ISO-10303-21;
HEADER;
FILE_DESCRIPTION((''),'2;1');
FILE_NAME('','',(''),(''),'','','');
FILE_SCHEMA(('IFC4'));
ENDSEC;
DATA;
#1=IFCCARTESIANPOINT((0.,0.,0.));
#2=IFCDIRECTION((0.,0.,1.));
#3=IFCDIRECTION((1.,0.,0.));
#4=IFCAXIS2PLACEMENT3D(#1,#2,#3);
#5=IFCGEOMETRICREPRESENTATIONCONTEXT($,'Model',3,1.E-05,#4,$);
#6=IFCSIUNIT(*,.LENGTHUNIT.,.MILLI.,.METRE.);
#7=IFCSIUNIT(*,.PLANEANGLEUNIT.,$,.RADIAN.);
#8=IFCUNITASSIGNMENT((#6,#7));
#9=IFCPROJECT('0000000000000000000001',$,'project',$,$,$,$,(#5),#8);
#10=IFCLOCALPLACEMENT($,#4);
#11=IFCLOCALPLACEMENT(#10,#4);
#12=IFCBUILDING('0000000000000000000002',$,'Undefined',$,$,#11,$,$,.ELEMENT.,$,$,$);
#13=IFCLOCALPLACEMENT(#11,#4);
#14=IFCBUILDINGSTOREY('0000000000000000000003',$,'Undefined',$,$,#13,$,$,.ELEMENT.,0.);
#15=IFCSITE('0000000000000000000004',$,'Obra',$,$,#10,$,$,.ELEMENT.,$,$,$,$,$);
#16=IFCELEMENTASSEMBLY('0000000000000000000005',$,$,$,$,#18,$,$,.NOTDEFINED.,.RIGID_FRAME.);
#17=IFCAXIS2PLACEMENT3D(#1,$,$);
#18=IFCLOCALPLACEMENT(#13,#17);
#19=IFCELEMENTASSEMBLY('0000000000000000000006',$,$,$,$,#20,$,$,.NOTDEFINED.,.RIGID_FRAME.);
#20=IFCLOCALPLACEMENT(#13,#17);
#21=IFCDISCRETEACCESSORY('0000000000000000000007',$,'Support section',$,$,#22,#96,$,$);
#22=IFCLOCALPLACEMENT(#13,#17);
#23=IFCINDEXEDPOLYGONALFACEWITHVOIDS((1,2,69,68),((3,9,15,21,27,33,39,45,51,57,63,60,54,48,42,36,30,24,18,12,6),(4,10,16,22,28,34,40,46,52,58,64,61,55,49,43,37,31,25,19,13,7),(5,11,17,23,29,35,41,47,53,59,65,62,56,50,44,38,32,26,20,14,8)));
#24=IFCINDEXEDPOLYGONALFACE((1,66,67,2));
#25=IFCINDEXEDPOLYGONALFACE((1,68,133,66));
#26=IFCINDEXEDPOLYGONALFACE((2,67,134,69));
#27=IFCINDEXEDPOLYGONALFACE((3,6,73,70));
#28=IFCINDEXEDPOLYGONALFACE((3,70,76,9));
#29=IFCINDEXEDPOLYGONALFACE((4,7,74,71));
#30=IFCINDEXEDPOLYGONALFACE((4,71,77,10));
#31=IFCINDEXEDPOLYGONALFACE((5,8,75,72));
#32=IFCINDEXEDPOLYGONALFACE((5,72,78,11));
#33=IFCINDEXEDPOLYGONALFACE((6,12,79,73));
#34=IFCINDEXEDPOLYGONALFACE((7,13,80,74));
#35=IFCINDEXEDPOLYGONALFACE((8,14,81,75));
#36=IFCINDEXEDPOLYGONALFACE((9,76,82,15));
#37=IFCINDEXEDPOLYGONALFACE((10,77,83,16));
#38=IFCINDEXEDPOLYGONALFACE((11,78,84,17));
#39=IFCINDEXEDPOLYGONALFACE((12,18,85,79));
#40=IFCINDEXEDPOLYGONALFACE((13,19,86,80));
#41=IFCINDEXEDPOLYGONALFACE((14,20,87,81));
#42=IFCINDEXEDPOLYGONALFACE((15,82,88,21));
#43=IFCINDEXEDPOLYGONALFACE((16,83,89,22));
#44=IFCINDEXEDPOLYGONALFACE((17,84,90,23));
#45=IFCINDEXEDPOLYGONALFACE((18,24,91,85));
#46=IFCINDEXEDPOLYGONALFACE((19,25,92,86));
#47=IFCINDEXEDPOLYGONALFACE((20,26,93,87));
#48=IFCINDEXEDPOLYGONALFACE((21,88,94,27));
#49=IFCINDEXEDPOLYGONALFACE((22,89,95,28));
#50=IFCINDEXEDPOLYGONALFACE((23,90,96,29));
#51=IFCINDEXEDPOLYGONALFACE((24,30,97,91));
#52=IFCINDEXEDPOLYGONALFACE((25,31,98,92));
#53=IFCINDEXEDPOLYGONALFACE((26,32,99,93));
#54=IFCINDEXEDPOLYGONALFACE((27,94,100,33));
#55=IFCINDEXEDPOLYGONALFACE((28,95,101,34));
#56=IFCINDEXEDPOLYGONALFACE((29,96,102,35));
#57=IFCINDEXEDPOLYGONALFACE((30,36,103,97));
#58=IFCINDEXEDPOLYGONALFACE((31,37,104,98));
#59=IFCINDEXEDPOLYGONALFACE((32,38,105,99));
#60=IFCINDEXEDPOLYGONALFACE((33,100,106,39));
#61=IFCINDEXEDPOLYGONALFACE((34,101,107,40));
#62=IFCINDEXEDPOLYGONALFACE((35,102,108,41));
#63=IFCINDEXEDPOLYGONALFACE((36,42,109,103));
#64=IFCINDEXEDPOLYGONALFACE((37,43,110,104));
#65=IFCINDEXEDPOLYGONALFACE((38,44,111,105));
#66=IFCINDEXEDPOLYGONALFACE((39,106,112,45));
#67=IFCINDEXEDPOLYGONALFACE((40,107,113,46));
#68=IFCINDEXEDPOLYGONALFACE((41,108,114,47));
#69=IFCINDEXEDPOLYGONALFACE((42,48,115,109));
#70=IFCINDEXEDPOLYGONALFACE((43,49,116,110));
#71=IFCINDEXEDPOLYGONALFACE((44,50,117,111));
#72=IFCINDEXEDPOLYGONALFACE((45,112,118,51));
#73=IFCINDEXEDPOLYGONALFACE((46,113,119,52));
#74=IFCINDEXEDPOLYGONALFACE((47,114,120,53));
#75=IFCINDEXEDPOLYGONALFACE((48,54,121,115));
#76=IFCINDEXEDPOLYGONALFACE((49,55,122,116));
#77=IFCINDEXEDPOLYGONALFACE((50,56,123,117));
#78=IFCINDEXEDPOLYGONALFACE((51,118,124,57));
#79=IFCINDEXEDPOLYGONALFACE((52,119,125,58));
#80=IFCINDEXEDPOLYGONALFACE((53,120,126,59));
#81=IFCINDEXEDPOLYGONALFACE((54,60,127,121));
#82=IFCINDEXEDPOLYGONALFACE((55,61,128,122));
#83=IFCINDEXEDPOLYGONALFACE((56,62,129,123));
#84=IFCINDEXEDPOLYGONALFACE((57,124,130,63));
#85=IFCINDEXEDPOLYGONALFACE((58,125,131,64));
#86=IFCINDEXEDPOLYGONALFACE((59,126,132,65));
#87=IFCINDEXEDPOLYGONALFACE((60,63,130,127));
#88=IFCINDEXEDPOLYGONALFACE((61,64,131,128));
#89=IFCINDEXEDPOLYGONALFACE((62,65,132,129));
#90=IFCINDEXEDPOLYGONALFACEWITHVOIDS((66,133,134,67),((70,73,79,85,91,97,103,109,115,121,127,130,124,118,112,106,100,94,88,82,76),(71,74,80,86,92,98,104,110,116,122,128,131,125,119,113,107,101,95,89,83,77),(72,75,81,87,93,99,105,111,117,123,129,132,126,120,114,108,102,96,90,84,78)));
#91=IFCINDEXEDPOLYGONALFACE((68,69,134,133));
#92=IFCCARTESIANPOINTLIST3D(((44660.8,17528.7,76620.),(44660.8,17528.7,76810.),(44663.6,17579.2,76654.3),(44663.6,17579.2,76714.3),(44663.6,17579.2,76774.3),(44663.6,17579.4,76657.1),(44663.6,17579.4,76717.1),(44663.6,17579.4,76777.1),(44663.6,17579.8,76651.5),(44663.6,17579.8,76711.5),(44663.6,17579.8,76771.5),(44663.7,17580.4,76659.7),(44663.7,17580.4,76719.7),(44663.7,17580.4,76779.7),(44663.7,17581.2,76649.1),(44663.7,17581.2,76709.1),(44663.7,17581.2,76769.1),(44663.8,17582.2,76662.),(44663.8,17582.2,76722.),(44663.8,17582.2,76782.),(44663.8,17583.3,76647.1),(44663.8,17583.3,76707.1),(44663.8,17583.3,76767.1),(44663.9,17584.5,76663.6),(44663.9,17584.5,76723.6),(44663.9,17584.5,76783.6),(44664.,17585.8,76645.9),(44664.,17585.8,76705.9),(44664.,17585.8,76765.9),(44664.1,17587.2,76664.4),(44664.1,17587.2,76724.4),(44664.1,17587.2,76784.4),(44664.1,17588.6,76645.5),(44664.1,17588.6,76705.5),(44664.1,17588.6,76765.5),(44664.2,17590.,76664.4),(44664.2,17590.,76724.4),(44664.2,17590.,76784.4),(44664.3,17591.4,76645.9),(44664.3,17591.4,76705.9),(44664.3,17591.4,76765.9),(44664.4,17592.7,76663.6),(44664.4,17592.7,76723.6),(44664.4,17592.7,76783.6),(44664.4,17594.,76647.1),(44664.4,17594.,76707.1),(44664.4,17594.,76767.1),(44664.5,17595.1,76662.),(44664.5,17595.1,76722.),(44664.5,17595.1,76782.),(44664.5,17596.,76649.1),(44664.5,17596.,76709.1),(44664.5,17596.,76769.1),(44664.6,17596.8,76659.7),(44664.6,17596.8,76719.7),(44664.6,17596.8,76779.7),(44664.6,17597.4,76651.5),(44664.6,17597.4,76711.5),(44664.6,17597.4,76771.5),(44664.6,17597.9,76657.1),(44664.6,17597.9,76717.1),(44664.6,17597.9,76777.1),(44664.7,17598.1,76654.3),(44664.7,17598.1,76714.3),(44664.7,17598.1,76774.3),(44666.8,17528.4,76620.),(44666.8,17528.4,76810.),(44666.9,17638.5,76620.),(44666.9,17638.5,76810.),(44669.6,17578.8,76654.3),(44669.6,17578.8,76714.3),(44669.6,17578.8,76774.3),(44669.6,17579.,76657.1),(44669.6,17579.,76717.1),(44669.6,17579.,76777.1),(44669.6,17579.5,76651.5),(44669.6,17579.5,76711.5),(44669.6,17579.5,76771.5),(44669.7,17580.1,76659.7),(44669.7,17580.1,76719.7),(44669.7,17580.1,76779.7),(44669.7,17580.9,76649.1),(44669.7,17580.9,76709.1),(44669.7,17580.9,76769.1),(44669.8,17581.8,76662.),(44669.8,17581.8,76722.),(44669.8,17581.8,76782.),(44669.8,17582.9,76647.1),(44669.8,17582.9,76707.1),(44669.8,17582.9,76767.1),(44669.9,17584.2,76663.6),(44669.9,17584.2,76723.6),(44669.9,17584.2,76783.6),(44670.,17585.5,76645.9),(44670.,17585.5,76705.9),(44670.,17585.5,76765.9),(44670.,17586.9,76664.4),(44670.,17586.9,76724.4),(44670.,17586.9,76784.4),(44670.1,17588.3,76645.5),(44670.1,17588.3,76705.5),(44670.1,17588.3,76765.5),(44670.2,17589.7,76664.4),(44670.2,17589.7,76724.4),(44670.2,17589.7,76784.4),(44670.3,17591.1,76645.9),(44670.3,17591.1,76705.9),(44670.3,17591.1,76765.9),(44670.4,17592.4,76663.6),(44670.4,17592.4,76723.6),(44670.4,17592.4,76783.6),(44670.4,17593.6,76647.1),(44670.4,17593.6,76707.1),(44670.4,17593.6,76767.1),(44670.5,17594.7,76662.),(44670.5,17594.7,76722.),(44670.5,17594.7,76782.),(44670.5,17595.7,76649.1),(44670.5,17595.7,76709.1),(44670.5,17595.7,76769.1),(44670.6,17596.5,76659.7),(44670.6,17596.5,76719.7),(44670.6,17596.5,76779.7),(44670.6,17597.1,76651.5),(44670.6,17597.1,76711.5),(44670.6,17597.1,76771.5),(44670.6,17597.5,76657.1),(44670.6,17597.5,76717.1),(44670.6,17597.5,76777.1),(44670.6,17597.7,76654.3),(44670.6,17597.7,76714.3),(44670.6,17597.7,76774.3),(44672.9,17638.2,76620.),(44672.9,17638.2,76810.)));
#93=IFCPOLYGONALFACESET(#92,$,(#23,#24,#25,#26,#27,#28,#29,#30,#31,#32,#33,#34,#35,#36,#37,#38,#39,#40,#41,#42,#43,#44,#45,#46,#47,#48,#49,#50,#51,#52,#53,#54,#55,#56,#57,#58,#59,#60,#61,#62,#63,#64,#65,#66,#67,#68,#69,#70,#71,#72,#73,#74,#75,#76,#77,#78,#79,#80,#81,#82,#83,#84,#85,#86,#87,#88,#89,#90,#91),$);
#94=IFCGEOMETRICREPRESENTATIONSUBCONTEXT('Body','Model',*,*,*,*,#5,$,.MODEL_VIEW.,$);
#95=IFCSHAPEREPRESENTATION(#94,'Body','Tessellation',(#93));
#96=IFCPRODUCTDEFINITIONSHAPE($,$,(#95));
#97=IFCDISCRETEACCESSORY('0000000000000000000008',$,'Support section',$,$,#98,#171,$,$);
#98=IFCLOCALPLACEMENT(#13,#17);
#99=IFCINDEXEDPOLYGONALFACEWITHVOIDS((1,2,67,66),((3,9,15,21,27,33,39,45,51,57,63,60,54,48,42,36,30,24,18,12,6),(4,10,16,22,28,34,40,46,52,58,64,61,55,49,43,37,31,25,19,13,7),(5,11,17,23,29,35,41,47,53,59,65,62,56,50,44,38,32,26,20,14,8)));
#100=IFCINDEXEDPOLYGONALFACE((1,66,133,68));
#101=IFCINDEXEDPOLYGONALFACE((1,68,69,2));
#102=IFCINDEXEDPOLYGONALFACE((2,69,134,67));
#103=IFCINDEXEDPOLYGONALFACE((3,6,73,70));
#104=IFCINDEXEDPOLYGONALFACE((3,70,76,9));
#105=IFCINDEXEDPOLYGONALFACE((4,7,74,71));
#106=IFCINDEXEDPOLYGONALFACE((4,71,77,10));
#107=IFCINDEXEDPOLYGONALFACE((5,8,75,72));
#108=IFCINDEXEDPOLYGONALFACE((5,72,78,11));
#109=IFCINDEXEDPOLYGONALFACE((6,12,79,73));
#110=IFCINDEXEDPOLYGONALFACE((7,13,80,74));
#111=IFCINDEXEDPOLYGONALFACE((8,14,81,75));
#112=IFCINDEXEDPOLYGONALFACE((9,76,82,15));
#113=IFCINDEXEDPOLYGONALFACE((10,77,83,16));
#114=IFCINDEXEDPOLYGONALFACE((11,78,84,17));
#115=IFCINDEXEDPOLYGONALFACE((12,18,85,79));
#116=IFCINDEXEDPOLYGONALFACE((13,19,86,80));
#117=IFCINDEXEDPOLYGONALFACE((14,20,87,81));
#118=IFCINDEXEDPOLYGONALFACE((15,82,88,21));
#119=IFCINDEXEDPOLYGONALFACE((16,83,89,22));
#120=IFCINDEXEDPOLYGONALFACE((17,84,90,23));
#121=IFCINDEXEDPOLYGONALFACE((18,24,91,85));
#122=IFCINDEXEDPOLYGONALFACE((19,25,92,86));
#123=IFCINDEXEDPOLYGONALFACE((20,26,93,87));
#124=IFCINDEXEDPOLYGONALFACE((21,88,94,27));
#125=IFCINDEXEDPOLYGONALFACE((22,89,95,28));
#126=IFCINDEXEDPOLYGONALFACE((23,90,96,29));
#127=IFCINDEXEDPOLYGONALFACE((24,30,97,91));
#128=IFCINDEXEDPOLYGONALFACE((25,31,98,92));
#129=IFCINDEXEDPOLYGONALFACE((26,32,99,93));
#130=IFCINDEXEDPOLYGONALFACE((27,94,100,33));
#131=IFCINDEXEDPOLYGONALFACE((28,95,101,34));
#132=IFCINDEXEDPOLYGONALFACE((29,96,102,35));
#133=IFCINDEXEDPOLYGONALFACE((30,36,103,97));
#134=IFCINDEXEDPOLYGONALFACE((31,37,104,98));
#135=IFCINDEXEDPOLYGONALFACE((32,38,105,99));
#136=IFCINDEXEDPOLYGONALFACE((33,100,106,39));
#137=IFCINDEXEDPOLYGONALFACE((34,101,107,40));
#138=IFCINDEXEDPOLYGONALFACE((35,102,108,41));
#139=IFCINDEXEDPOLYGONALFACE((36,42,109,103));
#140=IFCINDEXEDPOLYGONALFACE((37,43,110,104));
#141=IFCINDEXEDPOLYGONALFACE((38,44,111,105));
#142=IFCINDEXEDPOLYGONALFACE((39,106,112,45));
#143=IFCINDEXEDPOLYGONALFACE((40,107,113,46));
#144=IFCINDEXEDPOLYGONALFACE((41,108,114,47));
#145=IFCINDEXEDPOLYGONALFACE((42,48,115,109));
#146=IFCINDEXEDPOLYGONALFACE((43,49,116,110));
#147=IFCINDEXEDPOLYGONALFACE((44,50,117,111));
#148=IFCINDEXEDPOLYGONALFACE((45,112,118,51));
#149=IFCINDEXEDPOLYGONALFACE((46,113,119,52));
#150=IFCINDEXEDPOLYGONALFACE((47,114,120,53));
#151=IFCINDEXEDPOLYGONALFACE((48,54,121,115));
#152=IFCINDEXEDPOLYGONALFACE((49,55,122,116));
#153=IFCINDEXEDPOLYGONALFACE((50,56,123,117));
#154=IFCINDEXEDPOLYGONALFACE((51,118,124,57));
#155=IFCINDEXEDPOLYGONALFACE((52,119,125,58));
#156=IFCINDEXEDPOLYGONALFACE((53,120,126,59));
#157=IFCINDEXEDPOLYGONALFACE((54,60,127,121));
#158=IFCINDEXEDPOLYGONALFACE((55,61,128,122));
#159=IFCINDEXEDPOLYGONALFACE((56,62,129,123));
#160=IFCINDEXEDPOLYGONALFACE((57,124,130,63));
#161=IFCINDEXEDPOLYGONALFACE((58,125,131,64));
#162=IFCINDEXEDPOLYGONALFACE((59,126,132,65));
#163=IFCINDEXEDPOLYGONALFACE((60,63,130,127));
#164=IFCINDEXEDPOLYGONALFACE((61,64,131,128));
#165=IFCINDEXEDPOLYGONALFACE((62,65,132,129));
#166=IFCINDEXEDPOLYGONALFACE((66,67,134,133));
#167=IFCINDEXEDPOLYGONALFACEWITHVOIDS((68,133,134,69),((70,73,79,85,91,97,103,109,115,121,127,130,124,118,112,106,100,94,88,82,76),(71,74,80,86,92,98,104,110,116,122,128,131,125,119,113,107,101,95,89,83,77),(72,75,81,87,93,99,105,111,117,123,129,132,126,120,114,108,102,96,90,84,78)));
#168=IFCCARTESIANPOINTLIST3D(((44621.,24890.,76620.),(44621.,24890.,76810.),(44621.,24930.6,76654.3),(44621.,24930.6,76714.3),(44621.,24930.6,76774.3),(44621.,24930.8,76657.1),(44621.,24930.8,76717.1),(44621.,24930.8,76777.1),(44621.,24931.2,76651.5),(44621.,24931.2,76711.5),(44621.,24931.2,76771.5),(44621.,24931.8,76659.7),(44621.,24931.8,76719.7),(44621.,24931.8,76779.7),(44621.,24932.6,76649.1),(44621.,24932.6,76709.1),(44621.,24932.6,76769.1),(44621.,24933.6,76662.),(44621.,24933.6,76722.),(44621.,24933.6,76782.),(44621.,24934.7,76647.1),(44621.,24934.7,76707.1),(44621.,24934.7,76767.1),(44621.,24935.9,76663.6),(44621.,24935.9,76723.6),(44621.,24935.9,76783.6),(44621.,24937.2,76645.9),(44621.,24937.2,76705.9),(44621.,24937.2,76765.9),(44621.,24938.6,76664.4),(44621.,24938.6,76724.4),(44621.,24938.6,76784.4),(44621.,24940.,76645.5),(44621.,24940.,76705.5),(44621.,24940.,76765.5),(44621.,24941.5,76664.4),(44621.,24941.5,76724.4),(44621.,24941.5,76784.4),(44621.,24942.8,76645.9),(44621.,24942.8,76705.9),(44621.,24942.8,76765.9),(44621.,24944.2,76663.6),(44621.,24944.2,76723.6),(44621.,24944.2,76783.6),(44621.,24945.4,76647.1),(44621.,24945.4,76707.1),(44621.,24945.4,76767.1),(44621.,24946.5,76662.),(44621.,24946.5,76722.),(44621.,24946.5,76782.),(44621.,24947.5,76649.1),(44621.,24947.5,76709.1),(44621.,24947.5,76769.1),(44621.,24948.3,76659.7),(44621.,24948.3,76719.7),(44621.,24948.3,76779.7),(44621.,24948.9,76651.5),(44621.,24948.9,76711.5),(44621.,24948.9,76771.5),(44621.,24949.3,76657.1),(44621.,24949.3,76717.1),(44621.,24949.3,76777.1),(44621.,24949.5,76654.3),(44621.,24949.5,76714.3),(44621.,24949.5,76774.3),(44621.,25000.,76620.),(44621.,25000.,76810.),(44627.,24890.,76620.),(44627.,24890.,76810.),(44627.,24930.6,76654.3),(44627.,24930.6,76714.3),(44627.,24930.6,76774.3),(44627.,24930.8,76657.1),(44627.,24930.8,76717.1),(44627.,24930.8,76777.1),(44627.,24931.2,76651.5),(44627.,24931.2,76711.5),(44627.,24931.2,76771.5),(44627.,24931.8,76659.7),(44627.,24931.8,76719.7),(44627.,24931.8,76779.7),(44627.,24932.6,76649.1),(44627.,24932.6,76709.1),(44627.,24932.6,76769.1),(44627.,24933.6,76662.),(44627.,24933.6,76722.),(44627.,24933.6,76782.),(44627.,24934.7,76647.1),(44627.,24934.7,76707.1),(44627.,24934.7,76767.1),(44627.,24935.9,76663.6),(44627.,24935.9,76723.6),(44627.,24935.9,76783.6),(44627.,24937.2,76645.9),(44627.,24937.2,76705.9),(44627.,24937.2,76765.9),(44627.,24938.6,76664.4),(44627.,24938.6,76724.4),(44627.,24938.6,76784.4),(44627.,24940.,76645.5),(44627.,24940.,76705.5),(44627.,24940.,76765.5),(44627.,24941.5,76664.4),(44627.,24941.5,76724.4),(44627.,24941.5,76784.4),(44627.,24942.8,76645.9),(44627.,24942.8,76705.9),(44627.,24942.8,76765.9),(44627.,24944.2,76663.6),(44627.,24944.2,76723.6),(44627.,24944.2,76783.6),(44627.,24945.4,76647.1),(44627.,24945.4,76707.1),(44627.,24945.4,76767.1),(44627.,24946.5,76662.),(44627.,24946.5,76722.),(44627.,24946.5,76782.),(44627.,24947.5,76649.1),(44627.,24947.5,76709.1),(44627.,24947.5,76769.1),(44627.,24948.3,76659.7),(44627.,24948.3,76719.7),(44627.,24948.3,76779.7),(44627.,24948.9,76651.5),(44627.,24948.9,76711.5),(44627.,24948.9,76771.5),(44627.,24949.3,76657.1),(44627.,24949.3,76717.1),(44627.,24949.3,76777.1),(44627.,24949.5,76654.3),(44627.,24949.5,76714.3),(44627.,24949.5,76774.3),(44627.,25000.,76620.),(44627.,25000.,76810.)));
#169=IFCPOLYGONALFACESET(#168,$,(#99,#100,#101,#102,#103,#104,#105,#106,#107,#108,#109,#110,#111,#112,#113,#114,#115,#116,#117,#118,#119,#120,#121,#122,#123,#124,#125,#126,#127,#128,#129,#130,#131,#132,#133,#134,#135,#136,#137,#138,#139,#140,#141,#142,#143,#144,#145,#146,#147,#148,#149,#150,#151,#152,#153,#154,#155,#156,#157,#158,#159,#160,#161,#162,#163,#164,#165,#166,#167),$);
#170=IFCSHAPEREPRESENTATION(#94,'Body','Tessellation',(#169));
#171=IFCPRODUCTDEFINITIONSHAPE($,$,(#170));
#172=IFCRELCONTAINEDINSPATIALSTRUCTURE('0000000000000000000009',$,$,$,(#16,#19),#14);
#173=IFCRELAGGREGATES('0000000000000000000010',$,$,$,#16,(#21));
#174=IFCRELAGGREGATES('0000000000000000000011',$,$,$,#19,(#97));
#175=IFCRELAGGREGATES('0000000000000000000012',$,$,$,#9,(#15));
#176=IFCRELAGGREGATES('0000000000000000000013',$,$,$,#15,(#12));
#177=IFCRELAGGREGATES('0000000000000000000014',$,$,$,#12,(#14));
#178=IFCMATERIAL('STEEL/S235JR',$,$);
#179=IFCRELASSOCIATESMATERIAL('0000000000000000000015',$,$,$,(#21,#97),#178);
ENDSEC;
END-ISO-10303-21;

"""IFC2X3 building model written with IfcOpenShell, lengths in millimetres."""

from ifc_helpers import new_model, si_unit, frame, origin_with_axes, origin_2d_with_axis, place, context, subcontext, project, spatial, rectangle, circle, extrude, source, transform, mapped, material, element, aggregate, save


model = new_model("IFC2X3")

# Units and contexts
model_context = context("Model", 3, precision=1e-05, world=origin_with_axes())
body_context = subcontext(model_context, "Body", "Model", "MODEL_VIEW")
ifc_project = project(units=[si_unit("LENGTHUNIT", "METRE", prefix="MILLI"), si_unit("PLANEANGLEUNIT", "RADIAN")], contexts=[model_context])

# Site, building, storey
site_placement = place(None, origin_with_axes())
site = spatial("IfcSite", under=ifc_project, at=site_placement, Name="Obra", CompositionType="ELEMENT")
building_placement = place(site_placement, origin_with_axes())
building = spatial("IfcBuilding", under=site, at=building_placement, Name="Undefined", CompositionType="ELEMENT")
storey_placement = place(building_placement, origin_with_axes())
storey = spatial("IfcBuildingStorey", under=building, at=storey_placement, Name="Undefined", CompositionType="ELEMENT", Elevation=0.0)

# Element assemblies
ifc_material_1 = material(Name="STEEL/S235JR")
assembly_1_placement = place(storey_placement, origin_with_axes())
assembly_1 = element("IfcElementAssembly", 1, at=assembly_1_placement, inside=storey, AssemblyPlace="NOTDEFINED", PredefinedType="RIGID_FRAME")
assembly_2_placement = place(storey_placement, origin_with_axes())
assembly_2 = element("IfcElementAssembly", 2, at=assembly_2_placement, inside=storey, AssemblyPlace="NOTDEFINED", PredefinedType="RIGID_FRAME")

# Discrete accessories, openings
shared_shape = source(origin_with_axes(), body_context, "Body", "SweptSolid", [
    extrude(circle(Radius=9.5, at=origin_2d_with_axis()), frame((0.0, -9.2, 0.0), z_axis=(0.0, 1.0, 0.0), x_axis=(1.0, 0.0, 0.0)), (0.0, 0.0, 1.0), 6.2),
])
discrete_accessory_1_placement = place(assembly_1_placement, frame((44666.9, 17583.5, 76620.0), z_axis=(0.0, 0.0, 1.0), x_axis=(-0.055268, -0.998472, 0.0)))
discrete_accessory_1 = element("IfcDiscreteAccessory", 3, at=discrete_accessory_1_placement, material=ifc_material_1, Name="Support section", context=body_context, shape_type="SweptSolid", body=[
    extrude(rectangle(XDim=6.0, YDim=110.0, at=origin_2d_with_axis()), frame((0.0, 0.0, 190.0), z_axis=(0.0, 0.0, -1.0), x_axis=(0.0, 1.0, 0.0)), (0.0, 0.0, 1.0), 190.0),
])
opening_1_placement = place(assembly_1_placement, frame((44658.3, 17538.9, 76835.0), z_axis=(0.055268, 0.998472, 0.0), x_axis=(0.0, 0.0, -1.0)))
element("IfcOpeningElement", 4, at=opening_1_placement, cuts=discrete_accessory_1, ObjectType="Opening", context=body_context, shape_type="MappedRepresentation", body=[
    mapped(shared_shape, transform((60.0, 0.0, 50.0))),
    mapped(shared_shape, transform((120.0, 0.0, 50.0))),
    mapped(shared_shape, transform((180.0, 0.0, 50.0))),
])
aggregate(assembly_1, [discrete_accessory_1])
discrete_accessory_2_placement = place(assembly_2_placement, frame((44624.0, 24945.0, 76620.0), z_axis=(0.0, 0.0, 1.0), x_axis=(-0.000002, 1.0, 0.0)))
discrete_accessory_2 = element("IfcDiscreteAccessory", 5, at=discrete_accessory_2_placement, material=ifc_material_1, Name="Support section", context=body_context, shape_type="SweptSolid", body=[
    extrude(rectangle(XDim=6.0, YDim=110.0, at=origin_2d_with_axis()), frame((0.0, 0.0, 190.0), z_axis=(0.0, 0.0, -1.0), x_axis=(0.0, 1.0, 0.0)), (0.0, 0.0, 1.0), 190.0),
])
opening_2_placement = place(assembly_2_placement, frame((44630.1, 24990.0, 76835.0), z_axis=(0.000002, -1.0, 0.0), x_axis=(0.0, 0.0, -1.0)))
element("IfcOpeningElement", 6, at=opening_2_placement, cuts=discrete_accessory_2, ObjectType="Opening", context=body_context, shape_type="MappedRepresentation", body=[
    mapped(shared_shape, transform((60.0, 0.0, 50.0))),
    mapped(shared_shape, transform((120.0, 0.0, 50.0))),
    mapped(shared_shape, transform((180.0, 0.0, 50.0))),
])
aggregate(assembly_2, [discrete_accessory_2])

save(model, "model.ifc")
